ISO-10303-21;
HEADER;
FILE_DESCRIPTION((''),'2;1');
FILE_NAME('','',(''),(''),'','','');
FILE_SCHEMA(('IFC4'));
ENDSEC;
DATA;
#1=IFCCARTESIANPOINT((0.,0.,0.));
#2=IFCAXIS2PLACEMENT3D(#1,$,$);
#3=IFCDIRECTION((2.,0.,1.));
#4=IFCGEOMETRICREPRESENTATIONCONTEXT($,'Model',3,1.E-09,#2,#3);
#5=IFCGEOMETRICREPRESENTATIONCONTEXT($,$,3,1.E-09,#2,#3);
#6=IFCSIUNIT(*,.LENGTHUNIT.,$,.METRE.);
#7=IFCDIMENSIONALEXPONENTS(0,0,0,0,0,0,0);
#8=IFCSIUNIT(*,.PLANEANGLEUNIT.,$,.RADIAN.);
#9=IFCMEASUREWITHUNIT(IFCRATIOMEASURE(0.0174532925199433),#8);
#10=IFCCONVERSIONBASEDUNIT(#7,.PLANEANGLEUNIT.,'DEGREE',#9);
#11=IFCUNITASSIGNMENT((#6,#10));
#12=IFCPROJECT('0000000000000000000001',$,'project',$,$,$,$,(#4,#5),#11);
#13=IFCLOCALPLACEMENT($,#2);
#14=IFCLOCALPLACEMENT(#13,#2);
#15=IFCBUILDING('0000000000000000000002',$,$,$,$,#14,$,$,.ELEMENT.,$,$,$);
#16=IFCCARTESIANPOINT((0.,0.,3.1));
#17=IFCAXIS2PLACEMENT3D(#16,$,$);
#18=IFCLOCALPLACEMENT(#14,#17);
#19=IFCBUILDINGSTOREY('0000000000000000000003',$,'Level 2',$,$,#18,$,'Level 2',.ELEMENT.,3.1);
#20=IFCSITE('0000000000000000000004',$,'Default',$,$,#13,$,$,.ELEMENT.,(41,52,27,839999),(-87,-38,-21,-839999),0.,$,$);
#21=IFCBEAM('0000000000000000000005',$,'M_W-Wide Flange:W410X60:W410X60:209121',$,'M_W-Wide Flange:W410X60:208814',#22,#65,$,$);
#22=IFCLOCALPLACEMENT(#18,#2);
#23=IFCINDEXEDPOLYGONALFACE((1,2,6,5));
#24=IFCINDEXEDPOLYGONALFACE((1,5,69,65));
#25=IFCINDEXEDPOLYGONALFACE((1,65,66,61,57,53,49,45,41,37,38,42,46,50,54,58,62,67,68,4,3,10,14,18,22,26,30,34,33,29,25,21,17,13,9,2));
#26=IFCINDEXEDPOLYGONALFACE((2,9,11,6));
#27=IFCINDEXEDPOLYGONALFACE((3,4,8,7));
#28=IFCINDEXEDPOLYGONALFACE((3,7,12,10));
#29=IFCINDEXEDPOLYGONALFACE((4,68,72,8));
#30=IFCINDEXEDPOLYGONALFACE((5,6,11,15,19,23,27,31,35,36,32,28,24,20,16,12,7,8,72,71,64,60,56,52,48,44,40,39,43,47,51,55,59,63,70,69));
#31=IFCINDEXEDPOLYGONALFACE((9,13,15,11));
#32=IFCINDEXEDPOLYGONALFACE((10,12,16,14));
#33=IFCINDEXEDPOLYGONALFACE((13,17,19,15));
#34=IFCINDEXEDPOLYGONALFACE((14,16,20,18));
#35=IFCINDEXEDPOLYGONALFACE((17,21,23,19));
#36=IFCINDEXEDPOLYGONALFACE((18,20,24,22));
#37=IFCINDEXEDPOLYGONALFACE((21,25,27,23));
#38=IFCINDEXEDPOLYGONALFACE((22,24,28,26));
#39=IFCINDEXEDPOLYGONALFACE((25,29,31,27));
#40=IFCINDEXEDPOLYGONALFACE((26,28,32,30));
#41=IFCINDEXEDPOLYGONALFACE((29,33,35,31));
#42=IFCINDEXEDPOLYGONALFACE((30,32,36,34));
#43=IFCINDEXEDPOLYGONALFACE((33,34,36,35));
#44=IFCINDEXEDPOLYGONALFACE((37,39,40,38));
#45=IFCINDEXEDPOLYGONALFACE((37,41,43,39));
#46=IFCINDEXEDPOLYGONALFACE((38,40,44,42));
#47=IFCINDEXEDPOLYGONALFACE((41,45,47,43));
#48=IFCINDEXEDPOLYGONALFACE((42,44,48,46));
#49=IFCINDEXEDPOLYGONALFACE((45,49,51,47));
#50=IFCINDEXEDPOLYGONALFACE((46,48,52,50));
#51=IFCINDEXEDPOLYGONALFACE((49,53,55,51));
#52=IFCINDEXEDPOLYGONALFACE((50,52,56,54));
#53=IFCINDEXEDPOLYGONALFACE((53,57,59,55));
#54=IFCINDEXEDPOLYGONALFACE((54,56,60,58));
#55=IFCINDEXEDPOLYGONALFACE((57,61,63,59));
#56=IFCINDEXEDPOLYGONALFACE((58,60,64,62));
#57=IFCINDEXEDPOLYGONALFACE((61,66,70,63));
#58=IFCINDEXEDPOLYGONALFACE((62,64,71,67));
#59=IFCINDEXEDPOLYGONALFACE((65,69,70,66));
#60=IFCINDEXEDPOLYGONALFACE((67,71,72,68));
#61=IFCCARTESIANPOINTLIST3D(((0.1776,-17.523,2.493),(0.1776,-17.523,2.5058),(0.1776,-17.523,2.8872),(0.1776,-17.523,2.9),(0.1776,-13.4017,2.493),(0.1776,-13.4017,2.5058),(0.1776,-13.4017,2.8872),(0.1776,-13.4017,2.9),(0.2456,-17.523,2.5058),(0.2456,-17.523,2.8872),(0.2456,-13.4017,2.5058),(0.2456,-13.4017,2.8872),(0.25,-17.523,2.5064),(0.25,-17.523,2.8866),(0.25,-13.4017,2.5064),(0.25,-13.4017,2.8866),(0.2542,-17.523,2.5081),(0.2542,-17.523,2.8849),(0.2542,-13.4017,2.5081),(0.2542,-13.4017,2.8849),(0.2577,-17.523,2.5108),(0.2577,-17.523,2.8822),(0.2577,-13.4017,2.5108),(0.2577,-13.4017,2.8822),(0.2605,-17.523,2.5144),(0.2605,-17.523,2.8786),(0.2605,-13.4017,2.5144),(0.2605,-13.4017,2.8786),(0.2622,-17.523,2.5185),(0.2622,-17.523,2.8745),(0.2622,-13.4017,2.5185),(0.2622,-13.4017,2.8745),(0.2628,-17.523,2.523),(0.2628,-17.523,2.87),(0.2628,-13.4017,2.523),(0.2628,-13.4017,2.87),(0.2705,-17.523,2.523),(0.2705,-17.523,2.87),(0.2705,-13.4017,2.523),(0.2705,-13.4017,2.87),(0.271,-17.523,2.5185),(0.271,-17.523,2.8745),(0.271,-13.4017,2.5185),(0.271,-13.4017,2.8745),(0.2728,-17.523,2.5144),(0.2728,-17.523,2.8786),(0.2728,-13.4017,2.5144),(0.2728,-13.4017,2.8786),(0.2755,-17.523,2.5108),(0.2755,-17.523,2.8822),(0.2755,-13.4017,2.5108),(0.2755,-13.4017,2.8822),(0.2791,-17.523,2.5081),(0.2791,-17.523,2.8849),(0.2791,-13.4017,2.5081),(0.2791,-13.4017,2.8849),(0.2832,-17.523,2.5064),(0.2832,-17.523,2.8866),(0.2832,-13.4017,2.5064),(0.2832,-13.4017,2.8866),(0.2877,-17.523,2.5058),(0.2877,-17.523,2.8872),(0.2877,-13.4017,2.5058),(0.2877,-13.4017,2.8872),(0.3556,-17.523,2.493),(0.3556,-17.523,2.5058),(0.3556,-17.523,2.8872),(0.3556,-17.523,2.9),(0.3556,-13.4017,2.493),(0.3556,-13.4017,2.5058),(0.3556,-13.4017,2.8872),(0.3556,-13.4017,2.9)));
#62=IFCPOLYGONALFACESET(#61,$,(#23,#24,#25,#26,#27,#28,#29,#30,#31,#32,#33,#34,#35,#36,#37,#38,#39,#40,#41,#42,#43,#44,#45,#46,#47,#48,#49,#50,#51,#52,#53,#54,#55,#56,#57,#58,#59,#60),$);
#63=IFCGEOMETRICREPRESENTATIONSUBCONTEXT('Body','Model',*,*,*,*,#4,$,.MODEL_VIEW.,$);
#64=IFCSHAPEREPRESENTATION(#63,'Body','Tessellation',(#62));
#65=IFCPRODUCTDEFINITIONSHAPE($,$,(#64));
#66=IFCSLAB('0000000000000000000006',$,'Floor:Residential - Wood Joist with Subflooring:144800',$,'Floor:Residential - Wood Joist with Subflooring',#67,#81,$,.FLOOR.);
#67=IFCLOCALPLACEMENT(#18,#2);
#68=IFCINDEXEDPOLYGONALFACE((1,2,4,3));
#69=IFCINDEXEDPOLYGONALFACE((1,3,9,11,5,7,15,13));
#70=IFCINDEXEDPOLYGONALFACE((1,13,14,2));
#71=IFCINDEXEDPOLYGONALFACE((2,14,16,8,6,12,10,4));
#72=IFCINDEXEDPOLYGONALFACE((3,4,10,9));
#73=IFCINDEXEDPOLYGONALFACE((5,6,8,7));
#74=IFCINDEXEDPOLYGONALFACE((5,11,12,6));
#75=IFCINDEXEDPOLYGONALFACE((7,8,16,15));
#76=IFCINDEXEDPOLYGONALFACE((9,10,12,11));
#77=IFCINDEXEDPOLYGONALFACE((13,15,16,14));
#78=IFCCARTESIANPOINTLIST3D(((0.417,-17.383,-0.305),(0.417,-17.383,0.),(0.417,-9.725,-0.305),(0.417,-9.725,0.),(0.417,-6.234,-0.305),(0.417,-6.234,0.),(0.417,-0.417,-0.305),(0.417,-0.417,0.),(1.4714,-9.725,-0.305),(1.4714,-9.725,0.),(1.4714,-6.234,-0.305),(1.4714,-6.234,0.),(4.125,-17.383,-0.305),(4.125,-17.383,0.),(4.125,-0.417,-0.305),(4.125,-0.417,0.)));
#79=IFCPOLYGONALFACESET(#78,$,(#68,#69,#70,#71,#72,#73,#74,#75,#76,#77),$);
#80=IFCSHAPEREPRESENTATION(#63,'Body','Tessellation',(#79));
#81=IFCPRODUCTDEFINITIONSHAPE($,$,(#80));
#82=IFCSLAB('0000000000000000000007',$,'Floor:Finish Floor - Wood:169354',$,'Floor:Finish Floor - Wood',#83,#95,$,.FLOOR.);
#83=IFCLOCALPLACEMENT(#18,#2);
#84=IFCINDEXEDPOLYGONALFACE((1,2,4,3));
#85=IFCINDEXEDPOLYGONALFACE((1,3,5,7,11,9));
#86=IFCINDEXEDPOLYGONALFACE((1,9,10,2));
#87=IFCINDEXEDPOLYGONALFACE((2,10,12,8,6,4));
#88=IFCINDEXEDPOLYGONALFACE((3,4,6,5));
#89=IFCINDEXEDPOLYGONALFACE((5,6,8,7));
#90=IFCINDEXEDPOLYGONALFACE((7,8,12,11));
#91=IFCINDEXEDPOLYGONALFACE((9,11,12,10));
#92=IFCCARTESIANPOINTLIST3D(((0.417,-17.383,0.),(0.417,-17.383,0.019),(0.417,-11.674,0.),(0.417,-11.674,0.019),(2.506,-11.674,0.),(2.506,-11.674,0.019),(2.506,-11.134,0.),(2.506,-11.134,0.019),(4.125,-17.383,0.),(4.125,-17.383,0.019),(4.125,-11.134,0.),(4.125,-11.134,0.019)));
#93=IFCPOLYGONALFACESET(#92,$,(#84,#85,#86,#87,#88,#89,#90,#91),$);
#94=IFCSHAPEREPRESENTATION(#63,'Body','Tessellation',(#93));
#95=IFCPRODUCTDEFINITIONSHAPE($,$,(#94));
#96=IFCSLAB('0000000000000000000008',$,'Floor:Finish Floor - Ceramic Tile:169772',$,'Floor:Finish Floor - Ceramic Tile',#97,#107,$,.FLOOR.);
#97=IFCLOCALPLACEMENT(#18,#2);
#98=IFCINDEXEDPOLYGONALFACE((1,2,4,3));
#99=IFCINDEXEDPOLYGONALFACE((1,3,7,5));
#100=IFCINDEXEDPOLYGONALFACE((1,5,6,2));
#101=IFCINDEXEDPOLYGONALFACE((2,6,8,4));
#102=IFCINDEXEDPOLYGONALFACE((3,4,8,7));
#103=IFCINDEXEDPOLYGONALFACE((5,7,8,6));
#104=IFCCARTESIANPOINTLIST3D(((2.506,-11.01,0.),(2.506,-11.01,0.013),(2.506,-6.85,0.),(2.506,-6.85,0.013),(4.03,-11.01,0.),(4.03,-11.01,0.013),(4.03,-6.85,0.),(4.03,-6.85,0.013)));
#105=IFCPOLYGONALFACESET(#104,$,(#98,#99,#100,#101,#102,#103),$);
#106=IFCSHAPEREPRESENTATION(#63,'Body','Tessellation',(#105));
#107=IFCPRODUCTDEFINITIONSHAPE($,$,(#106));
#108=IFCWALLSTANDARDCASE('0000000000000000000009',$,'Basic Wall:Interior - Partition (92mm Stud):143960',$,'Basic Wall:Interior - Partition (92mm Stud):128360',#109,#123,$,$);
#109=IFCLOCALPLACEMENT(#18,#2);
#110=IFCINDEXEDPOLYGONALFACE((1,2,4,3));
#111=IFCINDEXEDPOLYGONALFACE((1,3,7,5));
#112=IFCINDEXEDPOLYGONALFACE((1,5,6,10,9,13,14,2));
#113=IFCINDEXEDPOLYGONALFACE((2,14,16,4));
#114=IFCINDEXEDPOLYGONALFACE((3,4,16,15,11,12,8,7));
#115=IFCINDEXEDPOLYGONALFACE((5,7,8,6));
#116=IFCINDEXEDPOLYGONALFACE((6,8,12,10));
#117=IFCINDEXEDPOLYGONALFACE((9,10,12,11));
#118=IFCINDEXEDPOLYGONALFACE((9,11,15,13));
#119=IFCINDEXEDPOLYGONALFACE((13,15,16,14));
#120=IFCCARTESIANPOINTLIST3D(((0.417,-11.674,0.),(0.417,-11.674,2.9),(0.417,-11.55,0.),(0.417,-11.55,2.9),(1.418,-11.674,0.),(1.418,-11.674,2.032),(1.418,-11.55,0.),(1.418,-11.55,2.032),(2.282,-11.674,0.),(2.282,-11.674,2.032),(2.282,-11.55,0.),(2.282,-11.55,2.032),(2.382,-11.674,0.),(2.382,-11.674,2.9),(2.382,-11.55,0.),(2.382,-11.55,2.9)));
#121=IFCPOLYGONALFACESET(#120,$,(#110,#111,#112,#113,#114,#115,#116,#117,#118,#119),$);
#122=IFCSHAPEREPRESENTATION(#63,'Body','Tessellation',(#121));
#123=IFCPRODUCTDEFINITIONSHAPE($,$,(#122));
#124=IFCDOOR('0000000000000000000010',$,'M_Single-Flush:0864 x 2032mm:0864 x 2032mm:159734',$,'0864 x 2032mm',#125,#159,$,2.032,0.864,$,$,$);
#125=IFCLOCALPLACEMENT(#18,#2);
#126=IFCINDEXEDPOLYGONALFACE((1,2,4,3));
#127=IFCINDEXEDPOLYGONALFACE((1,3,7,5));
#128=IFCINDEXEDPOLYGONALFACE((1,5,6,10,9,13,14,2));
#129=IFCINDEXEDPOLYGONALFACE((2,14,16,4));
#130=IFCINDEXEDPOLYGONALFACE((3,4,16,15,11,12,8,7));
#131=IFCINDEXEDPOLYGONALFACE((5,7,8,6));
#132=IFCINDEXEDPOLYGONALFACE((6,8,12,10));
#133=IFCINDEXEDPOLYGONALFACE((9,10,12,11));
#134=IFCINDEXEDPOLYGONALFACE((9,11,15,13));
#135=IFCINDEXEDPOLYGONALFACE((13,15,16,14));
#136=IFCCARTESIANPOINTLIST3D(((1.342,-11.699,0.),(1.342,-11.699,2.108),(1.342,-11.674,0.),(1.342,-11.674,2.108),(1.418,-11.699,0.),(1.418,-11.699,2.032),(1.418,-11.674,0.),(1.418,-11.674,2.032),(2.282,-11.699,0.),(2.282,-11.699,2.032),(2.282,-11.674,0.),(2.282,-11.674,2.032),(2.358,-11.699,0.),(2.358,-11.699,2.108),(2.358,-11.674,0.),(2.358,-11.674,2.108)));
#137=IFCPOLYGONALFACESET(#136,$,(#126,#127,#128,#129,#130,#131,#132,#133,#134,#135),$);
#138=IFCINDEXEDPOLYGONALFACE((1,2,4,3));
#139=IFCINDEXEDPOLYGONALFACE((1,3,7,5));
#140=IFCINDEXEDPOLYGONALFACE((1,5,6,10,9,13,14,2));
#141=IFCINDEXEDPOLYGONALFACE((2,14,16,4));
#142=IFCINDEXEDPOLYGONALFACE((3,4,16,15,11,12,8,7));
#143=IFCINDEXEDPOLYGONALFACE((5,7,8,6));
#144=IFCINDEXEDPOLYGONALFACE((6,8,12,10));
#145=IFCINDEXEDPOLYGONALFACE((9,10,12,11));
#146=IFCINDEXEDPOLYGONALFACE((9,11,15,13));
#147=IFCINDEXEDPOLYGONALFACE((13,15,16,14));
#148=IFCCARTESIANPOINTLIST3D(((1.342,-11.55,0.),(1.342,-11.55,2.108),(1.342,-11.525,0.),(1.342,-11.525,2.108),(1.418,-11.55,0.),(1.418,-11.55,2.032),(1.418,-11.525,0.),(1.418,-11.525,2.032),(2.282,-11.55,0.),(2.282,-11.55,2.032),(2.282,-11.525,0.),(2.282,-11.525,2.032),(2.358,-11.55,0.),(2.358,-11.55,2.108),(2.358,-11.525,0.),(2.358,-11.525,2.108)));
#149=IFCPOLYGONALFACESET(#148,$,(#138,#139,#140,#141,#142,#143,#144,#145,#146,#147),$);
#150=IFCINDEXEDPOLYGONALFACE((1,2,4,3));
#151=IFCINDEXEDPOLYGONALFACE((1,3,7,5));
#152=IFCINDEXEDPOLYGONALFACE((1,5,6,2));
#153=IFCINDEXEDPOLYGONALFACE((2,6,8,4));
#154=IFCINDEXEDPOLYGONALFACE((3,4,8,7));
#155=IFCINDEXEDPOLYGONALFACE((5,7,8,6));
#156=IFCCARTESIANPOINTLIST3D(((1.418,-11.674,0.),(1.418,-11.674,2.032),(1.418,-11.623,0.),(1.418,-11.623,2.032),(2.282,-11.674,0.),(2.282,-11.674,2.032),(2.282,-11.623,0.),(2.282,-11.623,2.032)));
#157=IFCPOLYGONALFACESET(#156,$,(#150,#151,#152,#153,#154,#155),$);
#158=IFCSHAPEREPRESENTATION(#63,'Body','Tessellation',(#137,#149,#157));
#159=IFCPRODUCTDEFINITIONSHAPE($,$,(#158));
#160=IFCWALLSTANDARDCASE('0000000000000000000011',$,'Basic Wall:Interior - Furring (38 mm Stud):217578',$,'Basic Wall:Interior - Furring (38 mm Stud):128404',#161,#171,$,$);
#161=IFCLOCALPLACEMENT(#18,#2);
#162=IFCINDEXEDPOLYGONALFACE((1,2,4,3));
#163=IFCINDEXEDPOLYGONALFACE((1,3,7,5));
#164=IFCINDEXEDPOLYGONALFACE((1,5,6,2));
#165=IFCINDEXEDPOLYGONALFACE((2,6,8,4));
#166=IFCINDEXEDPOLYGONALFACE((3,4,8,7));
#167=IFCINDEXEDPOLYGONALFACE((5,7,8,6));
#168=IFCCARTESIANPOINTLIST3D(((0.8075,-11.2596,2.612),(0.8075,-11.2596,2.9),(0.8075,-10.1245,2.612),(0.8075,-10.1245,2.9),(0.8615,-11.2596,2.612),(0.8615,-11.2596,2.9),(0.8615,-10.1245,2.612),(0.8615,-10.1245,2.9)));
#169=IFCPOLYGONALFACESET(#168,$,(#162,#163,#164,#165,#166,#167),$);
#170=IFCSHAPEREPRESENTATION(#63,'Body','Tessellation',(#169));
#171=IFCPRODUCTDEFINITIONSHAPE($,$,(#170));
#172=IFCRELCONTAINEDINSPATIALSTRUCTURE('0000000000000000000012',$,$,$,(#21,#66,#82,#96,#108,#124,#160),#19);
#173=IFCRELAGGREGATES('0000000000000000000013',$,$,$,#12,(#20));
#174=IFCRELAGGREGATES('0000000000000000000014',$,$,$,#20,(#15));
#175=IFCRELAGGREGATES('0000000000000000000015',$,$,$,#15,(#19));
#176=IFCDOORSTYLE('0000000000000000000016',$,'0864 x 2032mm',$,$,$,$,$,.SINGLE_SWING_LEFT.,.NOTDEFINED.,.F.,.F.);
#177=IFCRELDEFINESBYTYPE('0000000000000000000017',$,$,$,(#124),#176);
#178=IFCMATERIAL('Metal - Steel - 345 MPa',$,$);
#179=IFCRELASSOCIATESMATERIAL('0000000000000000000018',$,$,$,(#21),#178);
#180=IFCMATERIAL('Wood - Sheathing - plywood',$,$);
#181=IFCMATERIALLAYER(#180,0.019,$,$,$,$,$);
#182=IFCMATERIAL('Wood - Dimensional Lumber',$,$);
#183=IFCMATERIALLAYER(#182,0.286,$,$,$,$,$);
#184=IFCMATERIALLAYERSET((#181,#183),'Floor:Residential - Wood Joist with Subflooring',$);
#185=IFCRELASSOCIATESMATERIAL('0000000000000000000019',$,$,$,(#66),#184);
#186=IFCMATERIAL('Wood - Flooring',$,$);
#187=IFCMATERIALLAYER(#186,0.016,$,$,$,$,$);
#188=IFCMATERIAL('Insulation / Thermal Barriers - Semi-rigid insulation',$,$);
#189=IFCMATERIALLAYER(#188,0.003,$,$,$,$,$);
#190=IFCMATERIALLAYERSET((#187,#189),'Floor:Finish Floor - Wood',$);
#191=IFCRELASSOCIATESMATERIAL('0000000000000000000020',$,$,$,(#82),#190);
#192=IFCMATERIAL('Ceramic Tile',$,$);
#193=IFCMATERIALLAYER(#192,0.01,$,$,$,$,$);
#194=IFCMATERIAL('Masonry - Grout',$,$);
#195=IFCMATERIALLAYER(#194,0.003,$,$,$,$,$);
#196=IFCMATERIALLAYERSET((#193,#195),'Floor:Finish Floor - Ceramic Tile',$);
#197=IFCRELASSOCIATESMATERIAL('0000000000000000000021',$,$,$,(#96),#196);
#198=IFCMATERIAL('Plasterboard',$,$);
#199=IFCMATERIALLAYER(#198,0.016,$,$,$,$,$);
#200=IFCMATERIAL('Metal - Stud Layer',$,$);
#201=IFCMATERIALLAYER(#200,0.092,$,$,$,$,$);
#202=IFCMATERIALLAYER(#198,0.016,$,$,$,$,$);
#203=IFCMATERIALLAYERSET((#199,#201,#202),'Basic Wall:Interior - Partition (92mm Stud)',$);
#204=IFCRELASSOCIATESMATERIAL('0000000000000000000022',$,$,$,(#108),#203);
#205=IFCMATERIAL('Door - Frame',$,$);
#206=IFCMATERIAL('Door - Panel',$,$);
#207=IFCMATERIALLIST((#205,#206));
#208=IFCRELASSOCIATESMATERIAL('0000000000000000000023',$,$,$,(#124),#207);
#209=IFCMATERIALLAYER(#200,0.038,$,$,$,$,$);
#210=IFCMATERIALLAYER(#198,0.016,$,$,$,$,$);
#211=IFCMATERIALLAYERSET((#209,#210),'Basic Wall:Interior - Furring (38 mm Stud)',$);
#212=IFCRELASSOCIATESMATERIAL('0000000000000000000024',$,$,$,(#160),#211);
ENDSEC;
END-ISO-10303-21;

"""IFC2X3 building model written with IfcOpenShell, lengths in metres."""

from ifc_helpers import new_model, entity, si_unit, converted_unit, direction, frame, frame_2d, origin, origin_2d_with_axis, place, context, subcontext, project, spatial, polyline, rectangle, i_section, outline, extrude, source, transform, mapped, material, material_list, layer, layer_set, layer_usage, type_object, type_shapes, element, fill, save


model = new_model("IFC2X3")

# Units and contexts
model_context = context("Model", 3, precision=1e-09, world=origin(), true_north=direction((2.0, 0.0, 1.0)))
context_of_model = context(None, 3, precision=1e-09, world=origin(), true_north=direction((2.0, 0.0, 1.0)))
body_context = subcontext(model_context, "Body", "Model", "MODEL_VIEW")
ifc_project = project(units=[si_unit("LENGTHUNIT", "METRE"), converted_unit("PLANEANGLEUNIT", "DEGREE", entity("IfcRatioMeasure", 0.0174532925199433), si_unit("PLANEANGLEUNIT", "RADIAN"), dimensions=[0, 0, 0, 0, 0, 0, 0])], contexts=[model_context, context_of_model])

# Site, building, storey
site_placement = place(None, origin())
site = spatial("IfcSite", under=ifc_project, at=site_placement, Name="Default", CompositionType="ELEMENT", RefLatitude=(41, 52, 27, 839999), RefLongitude=(-87, -38, -21, -839999), RefElevation=0.0)
building_placement = place(site_placement, origin())
building = spatial("IfcBuilding", under=site, at=building_placement, CompositionType="ELEMENT")
storey_placement = place(building_placement, frame((0.0, 0.0, 3.1)))
storey = spatial("IfcBuildingStorey", under=building, at=storey_placement, Name="Level 2", LongName="Level 2", CompositionType="ELEMENT", Elevation=3.1)

# Beam
ifc_material_1 = material(Name="Metal - Steel - 345 MPa")
beam_placement = place(storey_placement, frame((0.2666, -13.4017, 2.9), z_axis=(0.0, 0.0, 1.0), x_axis=(0.0, -1.0, 0.0)))
element("IfcBeam", 1, at=beam_placement, inside=storey, material=ifc_material_1, Name="M_W-Wide Flange:W410X60:W410X60:209121", ObjectType="M_W-Wide Flange:W410X60:208814", context=body_context, shape_type="SweptSolid", body=[
    extrude(i_section(OverallWidth=0.178, OverallDepth=0.407, WebThickness=0.0077, FlangeThickness=0.0128, FilletRadius=0.0172, at=origin_2d_with_axis()), frame((0.0, 0.0, -0.2035), z_axis=(-1.0, 0.0, 0.0), x_axis=(0.0, -1.0, 0.0)), (0.0, 0.0, -1.0), 4.1213),
])

# Slabs
ifc_material_2 = material(Name="Wood - Sheathing - plywood")
ifc_layer_1 = layer(ifc_material_2, 0.019)
ifc_material_3 = material(Name="Wood - Dimensional Lumber")
ifc_layer_2 = layer(ifc_material_3, 0.286)
ifc_layer_set_1 = layer_set([ifc_layer_1, ifc_layer_2], Name="Floor:Residential - Wood Joist with Subflooring")
ifc_layer_usage_1 = layer_usage(ifc_layer_set_1, "AXIS3", "POSITIVE", 0.0)
slab_1_placement = place(storey_placement, frame((0.417, -17.383, -0.305)))
element("IfcSlab", 2, at=slab_1_placement, inside=storey, material=ifc_layer_usage_1, Name="Floor:Residential - Wood Joist with Subflooring:144800", ObjectType="Floor:Residential - Wood Joist with Subflooring", PredefinedType="FLOOR", context=body_context, shape_type="SweptSolid", body=[
    extrude(outline(polyline([(-1.854, 8.483), (-1.854, -8.483), (1.854, -8.483), (1.854, -0.825), (0.7996, -0.825), (0.7996, 2.666), (1.854, 2.666), (1.854, 8.483), (-1.854, 8.483)])), frame((1.854, 8.483, 0.305), z_axis=(0.0, 0.0, -1.0), x_axis=(-1.0, 0.0, 0.0)), (0.0, 0.0, 1.0), 0.305),
])
ifc_material_4 = material(Name="Wood - Flooring")
ifc_layer_3 = layer(ifc_material_4, 0.016)
ifc_material_5 = material(Name="Insulation / Thermal Barriers - Semi-rigid insulation")
ifc_layer_4 = layer(ifc_material_5, 0.003)
ifc_layer_set_2 = layer_set([ifc_layer_3, ifc_layer_4], Name="Floor:Finish Floor - Wood")
ifc_layer_usage_2 = layer_usage(ifc_layer_set_2, "AXIS3", "POSITIVE", 0.0)
slab_2_placement = place(storey_placement, frame((0.417, -17.383, 0.0)))
element("IfcSlab", 3, at=slab_2_placement, inside=storey, material=ifc_layer_usage_2, Name="Floor:Finish Floor - Wood:169354", ObjectType="Floor:Finish Floor - Wood", PredefinedType="FLOOR", context=body_context, shape_type="SweptSolid", body=[
    extrude(outline(polyline([(-1.854, -3.1245), (1.854, -3.1245), (1.854, 2.5845), (-0.235, 2.5845), (-0.235, 3.1245), (-1.854, 3.1245), (-1.854, -3.1245)])), frame((1.854, 3.1245, 0.019), z_axis=(0.0, 0.0, -1.0), x_axis=(-1.0, 0.0, 0.0)), (0.0, 0.0, 1.0), 0.019),
])
ifc_material_6 = material(Name="Ceramic Tile")
ifc_layer_5 = layer(ifc_material_6, 0.01)
ifc_material_7 = material(Name="Masonry - Grout")
ifc_layer_6 = layer(ifc_material_7, 0.003)
ifc_layer_set_3 = layer_set([ifc_layer_5, ifc_layer_6], Name="Floor:Finish Floor - Ceramic Tile")
ifc_layer_usage_3 = layer_usage(ifc_layer_set_3, "AXIS3", "POSITIVE", 0.0)
slab_3_placement = place(storey_placement, frame((2.506, -11.01, 0.0)))
element("IfcSlab", 4, at=slab_3_placement, inside=storey, material=ifc_layer_usage_3, Name="Floor:Finish Floor - Ceramic Tile:169772", ObjectType="Floor:Finish Floor - Ceramic Tile", PredefinedType="FLOOR", context=body_context, shape_type="SweptSolid", body=[
    extrude(rectangle(XDim=4.16, YDim=1.524, at=frame_2d((0.0, 0.0), x_axis=(0.0, -1.0))), frame((0.762, 2.08, 0.013), z_axis=(0.0, 0.0, -1.0), x_axis=(-1.0, 0.0, 0.0)), (0.0, 0.0, 1.0), 0.013),
])

# Shared definitions
ifc_material_8 = material(Name="Metal - Stud Layer")
ifc_material_9 = material(Name="Plasterboard")

# Wall, opening, door
ifc_layer_7 = layer(ifc_material_9, 0.016)
ifc_layer_8 = layer(ifc_material_8, 0.092)
ifc_layer_9 = layer(ifc_material_9, 0.016)
ifc_layer_set_4 = layer_set([ifc_layer_7, ifc_layer_8, ifc_layer_9], Name="Basic Wall:Interior - Partition (92mm Stud)")
ifc_layer_usage_4 = layer_usage(ifc_layer_set_4, "AXIS2", "NEGATIVE", 0.062)
wall_1_placement = place(storey_placement, frame((2.382, -11.612, 0.0), z_axis=(0.0, 0.0, 1.0), x_axis=(-1.0, 0.0, 0.0)))
wall_1 = element("IfcWallStandardCase", 5, at=wall_1_placement, inside=storey, material=ifc_layer_usage_4, Name="Basic Wall:Interior - Partition (92mm Stud):143960", ObjectType="Basic Wall:Interior - Partition (92mm Stud):128360", context=body_context, shape_type="SweptSolid", body=[
    extrude(rectangle(XDim=1.965, YDim=0.124, at=frame_2d((0.9825, 0.0), x_axis=(-1.0, 0.0))), origin(), (0.0, 0.0, 1.0), 2.9),
])
opening_1_placement = place(wall_1_placement, frame((0.1, -0.062, 0.0)))
opening_1 = element("IfcOpeningElement", 6, at=opening_1_placement, cuts=wall_1, ObjectType="Opening", context=body_context, shape_type="SweptSolid", body=[
    extrude(rectangle(XDim=0.864, YDim=2.032, at=frame_2d((1.016, 0.432), x_axis=(0.0, -1.0))), frame((0.0, 0.0, 0.0), z_axis=(0.0, 1.0, 0.0), x_axis=(0.0, 0.0, 1.0)), (0.0, 0.0, 1.0), 0.124),
])
ifc_material_10 = material(Name="Door - Frame")
ifc_material_11 = material(Name="Door - Panel")
ifc_material_list_1 = material_list([ifc_material_10, ifc_material_11])
door_style = type_object("IfcDoorStyle", Name="0864 x 2032mm", ConstructionType="NOTDEFINED", OperationType="SINGLE_SWING_LEFT", ParameterTakesPrecedence=False, Sizeable=False)
shared_shape_1 = source(origin(), body_context, "Body", "SweptSolid", [
    extrude(outline(polyline([(-0.508, -1.073), (0.508, -1.073), (0.508, 1.035), (0.432, 1.035), (0.432, -0.997), (-0.432, -0.997), (-0.432, 1.035), (-0.508, 1.035), (-0.508, -1.073)])), frame((0.432, 0.149, 1.035), z_axis=(0.0, -1.0, 0.0), x_axis=(-1.0, 0.0, 0.0)), (0.0, 0.0, 1.0), 0.025),
    extrude(outline(polyline([(-1.073, -0.508), (1.035, -0.508), (1.035, -0.432), (-0.997, -0.432), (-0.997, 0.432), (1.035, 0.432), (1.035, 0.508), (-1.073, 0.508), (-1.073, -0.508)])), frame((0.432, 0.0, 1.035), z_axis=(0.0, -1.0, 0.0), x_axis=(0.0, 0.0, -1.0)), (0.0, 0.0, 1.0), 0.025),
    extrude(rectangle(XDim=0.864, YDim=0.051, at=frame_2d((0.0, 0.0), x_axis=(1.0, 0.0))), frame((0.432, 0.0985, 0.0)), (0.0, 0.0, 1.0), 2.032),
])
type_shapes(door_style, [shared_shape_1])
door_placement = place(opening_1_placement, origin())
door = element("IfcDoor", 7, at=door_placement, inside=storey, type_object=door_style, material=ifc_material_list_1, Name="M_Single-Flush:0864 x 2032mm:0864 x 2032mm:159734", ObjectType="0864 x 2032mm", OverallHeight=2.032, OverallWidth=0.864, context=body_context, shape_type="MappedRepresentation", body=[
    mapped(shared_shape_1, transform((0.0, 0.0, 0.0), scale=1.0)),
])
fill(opening_1, door)

# Wall
ifc_layer_10 = layer(ifc_material_8, 0.038)
ifc_layer_11 = layer(ifc_material_9, 0.016)
ifc_layer_set_5 = layer_set([ifc_layer_10, ifc_layer_11], Name="Basic Wall:Interior - Furring (38 mm Stud)")
ifc_layer_usage_5 = layer_usage(ifc_layer_set_5, "AXIS2", "NEGATIVE", 0.027)
wall_2_placement = place(storey_placement, frame((0.8345, -11.2596, 2.612), z_axis=(0.0, 0.0, 1.0), x_axis=(0.0, 1.0, 0.0)))
element("IfcWallStandardCase", 8, at=wall_2_placement, inside=storey, material=ifc_layer_usage_5, Name="Basic Wall:Interior - Furring (38 mm Stud):217578", ObjectType="Basic Wall:Interior - Furring (38 mm Stud):128404", context=body_context, shape_type="SweptSolid", body=[
    extrude(rectangle(XDim=1.1351, YDim=0.054, at=frame_2d((0.5675, 0.0), x_axis=(-1.0, 0.0))), origin(), (0.0, 0.0, 1.0), 0.288),
])

save(model, "model.ifc")
